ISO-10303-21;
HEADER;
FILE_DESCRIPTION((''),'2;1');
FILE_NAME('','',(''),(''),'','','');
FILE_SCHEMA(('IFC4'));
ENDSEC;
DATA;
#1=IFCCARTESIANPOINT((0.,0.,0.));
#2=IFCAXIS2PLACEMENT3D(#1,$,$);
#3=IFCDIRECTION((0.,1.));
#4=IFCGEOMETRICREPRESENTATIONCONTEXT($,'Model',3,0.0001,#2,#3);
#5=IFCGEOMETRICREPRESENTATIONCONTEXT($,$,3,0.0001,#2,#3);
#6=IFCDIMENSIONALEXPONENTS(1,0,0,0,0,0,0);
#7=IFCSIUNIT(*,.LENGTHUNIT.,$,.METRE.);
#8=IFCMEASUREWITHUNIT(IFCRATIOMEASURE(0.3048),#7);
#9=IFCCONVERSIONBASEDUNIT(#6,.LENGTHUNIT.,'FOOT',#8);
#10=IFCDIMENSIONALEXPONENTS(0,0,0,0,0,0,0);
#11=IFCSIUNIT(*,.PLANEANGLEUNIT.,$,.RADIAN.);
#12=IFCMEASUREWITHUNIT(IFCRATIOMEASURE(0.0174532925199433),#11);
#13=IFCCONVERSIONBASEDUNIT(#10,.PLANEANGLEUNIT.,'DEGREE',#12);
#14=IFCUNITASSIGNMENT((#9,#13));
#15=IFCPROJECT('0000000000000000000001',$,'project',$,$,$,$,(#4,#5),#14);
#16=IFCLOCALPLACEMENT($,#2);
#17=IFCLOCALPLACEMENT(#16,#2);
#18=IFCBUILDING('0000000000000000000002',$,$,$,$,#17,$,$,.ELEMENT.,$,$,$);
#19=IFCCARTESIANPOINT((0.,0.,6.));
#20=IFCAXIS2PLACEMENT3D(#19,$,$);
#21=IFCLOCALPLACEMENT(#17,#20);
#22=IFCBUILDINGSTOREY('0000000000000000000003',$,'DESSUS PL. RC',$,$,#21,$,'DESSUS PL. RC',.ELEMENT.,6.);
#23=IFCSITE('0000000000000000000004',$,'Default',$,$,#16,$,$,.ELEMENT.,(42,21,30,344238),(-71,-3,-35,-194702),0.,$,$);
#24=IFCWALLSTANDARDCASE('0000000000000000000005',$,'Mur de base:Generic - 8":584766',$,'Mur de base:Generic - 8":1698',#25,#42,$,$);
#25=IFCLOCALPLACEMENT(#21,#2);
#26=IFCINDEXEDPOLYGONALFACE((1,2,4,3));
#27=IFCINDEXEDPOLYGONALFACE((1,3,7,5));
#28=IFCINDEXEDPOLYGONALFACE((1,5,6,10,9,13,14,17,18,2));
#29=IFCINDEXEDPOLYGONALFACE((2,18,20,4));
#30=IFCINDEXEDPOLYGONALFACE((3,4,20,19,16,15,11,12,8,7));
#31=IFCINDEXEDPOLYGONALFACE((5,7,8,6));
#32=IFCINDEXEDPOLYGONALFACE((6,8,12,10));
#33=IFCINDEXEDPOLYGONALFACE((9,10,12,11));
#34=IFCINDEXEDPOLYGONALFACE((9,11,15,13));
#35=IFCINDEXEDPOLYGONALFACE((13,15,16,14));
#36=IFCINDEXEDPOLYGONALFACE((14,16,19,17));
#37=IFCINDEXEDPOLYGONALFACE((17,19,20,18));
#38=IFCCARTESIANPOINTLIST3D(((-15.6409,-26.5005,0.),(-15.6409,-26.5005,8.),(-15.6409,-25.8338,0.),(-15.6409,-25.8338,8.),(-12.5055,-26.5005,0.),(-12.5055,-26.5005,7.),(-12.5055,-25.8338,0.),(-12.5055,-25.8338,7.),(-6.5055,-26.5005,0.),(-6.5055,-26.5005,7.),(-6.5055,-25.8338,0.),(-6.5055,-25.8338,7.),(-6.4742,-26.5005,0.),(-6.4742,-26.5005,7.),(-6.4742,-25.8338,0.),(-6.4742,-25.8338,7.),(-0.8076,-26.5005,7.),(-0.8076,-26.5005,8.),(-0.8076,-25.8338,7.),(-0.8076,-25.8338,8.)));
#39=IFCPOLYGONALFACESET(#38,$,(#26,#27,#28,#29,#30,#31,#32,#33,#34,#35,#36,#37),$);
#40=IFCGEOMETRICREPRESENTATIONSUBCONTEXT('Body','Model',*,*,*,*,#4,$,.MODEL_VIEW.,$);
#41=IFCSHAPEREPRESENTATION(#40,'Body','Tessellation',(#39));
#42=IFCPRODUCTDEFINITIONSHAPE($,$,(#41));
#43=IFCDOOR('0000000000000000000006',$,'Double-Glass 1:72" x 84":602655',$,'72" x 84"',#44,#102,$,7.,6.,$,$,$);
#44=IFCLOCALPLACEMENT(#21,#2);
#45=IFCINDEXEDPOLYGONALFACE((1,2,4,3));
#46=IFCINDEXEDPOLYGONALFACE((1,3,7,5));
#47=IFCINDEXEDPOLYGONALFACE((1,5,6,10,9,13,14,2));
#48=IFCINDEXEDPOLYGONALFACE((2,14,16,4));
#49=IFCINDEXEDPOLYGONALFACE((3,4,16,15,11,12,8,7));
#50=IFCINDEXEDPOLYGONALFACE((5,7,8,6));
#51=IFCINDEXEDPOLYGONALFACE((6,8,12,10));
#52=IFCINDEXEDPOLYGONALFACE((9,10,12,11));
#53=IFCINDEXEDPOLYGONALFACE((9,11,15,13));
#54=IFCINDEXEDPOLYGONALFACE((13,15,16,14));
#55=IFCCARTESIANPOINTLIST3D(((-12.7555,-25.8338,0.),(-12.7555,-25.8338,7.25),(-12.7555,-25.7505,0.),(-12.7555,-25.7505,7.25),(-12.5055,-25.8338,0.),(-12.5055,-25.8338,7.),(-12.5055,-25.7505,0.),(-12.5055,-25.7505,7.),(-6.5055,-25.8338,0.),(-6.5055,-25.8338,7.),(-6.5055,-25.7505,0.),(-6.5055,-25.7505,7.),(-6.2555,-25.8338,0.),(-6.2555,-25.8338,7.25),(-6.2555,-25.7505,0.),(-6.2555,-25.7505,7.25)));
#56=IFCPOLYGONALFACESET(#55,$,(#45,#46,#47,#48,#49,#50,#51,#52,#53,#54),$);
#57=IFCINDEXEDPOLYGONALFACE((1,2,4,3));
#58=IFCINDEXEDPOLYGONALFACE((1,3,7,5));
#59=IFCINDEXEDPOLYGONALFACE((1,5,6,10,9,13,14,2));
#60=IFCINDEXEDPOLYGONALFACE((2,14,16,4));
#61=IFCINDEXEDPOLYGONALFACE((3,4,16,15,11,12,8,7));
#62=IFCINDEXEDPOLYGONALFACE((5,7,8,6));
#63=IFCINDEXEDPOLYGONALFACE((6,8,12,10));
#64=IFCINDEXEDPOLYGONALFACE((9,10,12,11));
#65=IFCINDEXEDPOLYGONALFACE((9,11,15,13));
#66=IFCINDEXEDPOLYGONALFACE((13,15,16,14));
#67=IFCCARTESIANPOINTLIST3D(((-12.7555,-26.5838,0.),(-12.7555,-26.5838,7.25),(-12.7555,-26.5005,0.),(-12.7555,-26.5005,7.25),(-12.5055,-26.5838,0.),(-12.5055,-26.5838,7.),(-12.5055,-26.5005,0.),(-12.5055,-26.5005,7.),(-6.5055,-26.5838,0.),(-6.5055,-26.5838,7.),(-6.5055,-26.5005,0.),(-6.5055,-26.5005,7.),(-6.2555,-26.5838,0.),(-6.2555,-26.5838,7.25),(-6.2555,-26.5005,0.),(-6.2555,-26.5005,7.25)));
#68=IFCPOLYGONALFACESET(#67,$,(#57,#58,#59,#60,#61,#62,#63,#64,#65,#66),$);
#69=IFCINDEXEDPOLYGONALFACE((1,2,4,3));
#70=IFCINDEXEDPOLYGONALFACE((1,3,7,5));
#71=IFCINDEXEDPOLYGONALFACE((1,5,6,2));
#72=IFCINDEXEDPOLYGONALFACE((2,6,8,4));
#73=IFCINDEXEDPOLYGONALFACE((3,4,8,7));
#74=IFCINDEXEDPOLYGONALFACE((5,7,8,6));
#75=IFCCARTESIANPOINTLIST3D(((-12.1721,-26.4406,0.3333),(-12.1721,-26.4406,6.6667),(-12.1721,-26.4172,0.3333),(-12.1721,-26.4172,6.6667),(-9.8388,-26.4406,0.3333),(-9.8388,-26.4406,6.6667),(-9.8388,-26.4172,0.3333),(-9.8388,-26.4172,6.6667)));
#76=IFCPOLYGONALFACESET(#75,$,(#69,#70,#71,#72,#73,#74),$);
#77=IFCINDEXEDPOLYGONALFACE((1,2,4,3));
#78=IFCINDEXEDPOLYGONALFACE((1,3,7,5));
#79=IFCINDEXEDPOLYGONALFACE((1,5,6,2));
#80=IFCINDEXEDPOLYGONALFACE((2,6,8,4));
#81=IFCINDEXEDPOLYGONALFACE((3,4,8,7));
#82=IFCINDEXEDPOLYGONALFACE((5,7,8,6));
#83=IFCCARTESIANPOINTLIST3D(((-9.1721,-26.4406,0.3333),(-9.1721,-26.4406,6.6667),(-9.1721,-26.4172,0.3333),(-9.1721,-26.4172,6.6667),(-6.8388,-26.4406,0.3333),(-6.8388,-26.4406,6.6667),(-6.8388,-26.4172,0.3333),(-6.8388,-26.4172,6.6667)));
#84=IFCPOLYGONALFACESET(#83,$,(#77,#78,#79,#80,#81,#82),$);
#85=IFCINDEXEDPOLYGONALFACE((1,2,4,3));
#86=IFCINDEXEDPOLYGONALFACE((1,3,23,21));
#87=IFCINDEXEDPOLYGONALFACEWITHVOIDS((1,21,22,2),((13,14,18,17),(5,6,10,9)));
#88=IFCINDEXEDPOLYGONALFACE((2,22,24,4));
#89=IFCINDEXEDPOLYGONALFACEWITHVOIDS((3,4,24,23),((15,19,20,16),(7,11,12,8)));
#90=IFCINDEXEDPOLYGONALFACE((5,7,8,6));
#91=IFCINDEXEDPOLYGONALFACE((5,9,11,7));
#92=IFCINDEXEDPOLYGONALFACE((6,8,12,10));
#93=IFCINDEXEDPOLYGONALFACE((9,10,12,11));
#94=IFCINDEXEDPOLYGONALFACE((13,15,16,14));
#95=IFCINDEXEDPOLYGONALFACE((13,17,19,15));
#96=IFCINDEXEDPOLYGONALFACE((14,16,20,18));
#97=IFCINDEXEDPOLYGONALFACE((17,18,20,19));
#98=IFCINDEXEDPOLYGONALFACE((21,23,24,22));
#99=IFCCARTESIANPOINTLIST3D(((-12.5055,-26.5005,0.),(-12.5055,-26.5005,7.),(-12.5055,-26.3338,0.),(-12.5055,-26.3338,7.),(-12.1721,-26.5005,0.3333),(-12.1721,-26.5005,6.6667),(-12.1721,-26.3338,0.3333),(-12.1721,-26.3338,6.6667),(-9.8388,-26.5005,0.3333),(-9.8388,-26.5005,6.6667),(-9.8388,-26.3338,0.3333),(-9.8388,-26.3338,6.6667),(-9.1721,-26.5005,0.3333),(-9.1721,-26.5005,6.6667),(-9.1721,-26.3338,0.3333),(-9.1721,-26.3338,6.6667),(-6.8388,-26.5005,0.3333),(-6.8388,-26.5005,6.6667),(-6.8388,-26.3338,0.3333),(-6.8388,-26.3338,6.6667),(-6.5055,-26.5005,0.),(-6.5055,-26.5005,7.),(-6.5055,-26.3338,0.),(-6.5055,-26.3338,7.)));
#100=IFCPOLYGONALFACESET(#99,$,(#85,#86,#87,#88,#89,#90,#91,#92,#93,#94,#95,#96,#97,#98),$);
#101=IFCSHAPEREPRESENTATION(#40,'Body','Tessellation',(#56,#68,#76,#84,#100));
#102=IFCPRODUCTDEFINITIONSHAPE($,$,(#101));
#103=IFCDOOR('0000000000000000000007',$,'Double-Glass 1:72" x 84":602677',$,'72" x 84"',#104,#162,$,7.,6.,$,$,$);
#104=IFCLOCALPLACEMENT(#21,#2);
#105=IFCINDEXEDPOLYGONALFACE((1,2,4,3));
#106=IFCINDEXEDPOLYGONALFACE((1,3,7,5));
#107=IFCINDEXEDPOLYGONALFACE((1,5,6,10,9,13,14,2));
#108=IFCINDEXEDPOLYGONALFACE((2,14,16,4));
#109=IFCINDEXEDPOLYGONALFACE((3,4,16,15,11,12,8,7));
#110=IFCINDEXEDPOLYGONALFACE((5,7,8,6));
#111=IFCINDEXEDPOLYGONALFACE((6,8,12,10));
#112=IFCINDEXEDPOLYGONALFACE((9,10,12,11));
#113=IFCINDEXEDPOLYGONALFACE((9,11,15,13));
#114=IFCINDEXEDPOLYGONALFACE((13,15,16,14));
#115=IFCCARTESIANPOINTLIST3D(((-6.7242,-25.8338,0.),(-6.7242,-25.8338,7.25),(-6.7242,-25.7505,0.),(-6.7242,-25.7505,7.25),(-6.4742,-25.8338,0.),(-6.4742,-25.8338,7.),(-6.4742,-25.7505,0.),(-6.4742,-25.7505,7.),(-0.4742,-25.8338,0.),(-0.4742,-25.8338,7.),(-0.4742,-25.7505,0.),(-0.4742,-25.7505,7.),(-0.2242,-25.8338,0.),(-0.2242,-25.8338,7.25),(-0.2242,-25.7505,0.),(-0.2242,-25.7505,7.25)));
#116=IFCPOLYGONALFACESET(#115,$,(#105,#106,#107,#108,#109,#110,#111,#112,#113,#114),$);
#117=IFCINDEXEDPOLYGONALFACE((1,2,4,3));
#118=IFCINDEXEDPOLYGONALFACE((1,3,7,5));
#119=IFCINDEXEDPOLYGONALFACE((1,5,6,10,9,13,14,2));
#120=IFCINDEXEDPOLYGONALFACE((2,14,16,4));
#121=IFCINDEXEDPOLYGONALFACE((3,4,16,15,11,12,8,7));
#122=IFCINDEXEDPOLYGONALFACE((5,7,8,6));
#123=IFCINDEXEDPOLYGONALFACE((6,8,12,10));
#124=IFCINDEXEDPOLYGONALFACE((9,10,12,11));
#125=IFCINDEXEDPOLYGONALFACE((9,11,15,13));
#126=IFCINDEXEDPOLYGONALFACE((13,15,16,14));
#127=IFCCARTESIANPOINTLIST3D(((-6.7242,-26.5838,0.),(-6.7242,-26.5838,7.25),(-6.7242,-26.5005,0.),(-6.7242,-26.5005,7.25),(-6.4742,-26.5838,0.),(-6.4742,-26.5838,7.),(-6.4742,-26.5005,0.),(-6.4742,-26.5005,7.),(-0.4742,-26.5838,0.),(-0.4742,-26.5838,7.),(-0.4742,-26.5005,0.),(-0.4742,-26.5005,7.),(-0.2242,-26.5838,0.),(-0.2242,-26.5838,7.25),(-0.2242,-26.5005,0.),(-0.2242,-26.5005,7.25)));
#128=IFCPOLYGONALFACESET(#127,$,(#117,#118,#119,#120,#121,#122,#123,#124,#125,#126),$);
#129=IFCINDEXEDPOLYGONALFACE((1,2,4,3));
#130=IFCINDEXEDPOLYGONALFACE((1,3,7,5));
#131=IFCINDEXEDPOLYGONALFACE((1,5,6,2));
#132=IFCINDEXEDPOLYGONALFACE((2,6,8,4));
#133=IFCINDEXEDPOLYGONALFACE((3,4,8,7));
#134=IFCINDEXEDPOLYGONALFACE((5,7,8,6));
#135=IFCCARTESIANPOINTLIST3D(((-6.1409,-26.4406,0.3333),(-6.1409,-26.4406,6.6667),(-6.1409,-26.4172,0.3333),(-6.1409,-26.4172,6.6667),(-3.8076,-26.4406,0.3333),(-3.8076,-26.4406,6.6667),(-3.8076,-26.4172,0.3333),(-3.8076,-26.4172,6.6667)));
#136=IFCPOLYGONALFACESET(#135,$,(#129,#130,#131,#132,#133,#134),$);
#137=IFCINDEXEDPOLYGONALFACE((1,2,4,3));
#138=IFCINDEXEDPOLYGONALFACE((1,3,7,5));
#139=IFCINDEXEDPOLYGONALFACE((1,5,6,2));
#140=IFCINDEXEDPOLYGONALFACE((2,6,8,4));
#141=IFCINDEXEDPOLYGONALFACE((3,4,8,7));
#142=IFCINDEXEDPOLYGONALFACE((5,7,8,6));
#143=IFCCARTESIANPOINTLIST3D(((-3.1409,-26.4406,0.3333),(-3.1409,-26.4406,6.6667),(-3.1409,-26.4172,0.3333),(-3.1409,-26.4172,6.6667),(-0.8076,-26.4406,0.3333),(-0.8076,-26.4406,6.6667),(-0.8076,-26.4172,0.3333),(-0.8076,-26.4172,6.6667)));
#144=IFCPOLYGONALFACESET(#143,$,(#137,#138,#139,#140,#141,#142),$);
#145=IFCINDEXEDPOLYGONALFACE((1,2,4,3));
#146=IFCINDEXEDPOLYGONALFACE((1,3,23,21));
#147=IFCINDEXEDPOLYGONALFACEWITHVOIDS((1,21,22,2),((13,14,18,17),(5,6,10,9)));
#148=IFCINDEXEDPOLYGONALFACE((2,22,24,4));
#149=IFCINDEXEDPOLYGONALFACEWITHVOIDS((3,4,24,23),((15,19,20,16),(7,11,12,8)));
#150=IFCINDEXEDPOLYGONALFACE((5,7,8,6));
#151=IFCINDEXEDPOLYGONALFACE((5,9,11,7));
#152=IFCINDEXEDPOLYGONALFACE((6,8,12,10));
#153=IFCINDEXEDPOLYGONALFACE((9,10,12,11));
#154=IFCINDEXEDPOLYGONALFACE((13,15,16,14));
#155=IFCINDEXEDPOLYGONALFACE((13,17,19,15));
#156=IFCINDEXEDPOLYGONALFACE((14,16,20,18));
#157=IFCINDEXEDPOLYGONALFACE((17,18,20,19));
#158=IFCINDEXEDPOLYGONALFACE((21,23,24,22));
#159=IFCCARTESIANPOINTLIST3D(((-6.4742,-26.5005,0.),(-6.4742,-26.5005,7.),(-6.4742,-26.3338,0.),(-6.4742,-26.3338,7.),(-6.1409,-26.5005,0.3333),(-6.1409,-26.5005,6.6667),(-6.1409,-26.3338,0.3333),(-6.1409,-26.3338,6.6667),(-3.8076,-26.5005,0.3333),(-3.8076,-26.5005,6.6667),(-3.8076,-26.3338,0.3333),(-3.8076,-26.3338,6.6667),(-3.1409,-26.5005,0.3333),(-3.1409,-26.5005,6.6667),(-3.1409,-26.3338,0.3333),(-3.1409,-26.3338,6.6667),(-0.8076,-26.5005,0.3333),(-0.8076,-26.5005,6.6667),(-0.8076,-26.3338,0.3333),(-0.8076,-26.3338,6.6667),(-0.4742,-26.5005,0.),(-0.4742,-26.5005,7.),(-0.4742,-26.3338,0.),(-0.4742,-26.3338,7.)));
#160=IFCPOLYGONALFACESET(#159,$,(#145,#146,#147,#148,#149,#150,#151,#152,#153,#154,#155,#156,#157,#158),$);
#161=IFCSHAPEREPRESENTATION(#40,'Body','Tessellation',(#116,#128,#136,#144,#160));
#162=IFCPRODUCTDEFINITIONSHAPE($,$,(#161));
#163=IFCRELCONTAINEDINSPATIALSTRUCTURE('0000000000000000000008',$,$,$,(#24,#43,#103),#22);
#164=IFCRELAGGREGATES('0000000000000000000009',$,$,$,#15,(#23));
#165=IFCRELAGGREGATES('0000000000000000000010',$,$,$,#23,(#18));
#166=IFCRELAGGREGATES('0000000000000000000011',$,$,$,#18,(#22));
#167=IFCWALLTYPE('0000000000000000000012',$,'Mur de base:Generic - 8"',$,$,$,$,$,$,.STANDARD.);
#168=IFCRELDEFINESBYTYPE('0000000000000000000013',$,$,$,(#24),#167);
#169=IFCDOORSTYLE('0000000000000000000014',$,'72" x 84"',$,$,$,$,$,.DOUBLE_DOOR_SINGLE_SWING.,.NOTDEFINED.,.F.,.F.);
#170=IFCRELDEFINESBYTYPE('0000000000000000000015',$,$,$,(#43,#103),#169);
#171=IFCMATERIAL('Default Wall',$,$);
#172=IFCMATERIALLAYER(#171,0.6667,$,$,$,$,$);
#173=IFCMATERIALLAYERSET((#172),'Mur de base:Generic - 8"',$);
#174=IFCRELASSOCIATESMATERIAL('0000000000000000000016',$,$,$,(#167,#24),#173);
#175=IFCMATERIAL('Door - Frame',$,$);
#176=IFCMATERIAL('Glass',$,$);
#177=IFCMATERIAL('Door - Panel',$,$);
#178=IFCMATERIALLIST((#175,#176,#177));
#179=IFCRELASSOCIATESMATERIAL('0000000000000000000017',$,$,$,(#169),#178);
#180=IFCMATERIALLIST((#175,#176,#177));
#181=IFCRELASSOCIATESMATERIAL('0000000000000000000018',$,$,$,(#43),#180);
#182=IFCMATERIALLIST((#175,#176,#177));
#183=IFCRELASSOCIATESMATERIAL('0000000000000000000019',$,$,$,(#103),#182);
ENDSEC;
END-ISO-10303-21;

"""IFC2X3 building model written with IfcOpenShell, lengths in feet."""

from ifc_helpers import new_model, entity, si_unit, converted_unit, direction, frame, frame_2d, origin, origin_2d_with_axis, place, context, subcontext, project, spatial, polyline, rectangle, outline, extrude, source, transform, mapped, material, material_list, layer, layer_set, layer_usage, type_object, type_shapes, element, fill, save


model = new_model("IFC2X3")

# Units and contexts
model_context = context("Model", 3, precision=0.0001, world=origin(), true_north=direction((0.0, 1.0)))
context_of_model = context(None, 3, precision=0.0001, world=origin(), true_north=direction((0.0, 1.0)))
body_context = subcontext(model_context, "Body", "Model", "MODEL_VIEW")
ifc_project = project(units=[converted_unit("LENGTHUNIT", "FOOT", entity("IfcRatioMeasure", 0.3048), si_unit("LENGTHUNIT", "METRE"), dimensions=[1, 0, 0, 0, 0, 0, 0]), converted_unit("PLANEANGLEUNIT", "DEGREE", entity("IfcRatioMeasure", 0.0174532925199433), si_unit("PLANEANGLEUNIT", "RADIAN"), dimensions=[0, 0, 0, 0, 0, 0, 0])], contexts=[model_context, context_of_model])

# Site, building, storey
site_placement = place(None, origin())
site = spatial("IfcSite", under=ifc_project, at=site_placement, Name="Default", CompositionType="ELEMENT", RefLatitude=(42, 21, 30, 344238), RefLongitude=(-71, -3, -35, -194702), RefElevation=0.0)
building_placement = place(site_placement, origin())
building = spatial("IfcBuilding", under=site, at=building_placement, CompositionType="ELEMENT")
storey_placement = place(building_placement, frame((0.0, 0.0, 6.0)))
storey = spatial("IfcBuildingStorey", under=building, at=storey_placement, Name="DESSUS PL. RC", LongName="DESSUS PL. RC", CompositionType="ELEMENT", Elevation=6.0)

# Shared definitions
ifc_material_1 = material(Name="Default Wall")
ifc_material_2 = material(Name="Door - Frame")
ifc_material_3 = material(Name="Glass")
ifc_material_4 = material(Name="Door - Panel")

# Shared definitions
ifc_layer_1 = layer(ifc_material_1, 0.6667)
ifc_layer_set_1 = layer_set([ifc_layer_1], Name="Mur de base:Generic - 8\"")
wall_type_1 = type_object("IfcWallType", Name="Mur de base:Generic - 8\"", PredefinedType="STANDARD", material=ifc_layer_set_1)
ifc_material_list_1 = material_list([ifc_material_2, ifc_material_3, ifc_material_4])
door_style_1 = type_object("IfcDoorStyle", Name="72\" x 84\"", ConstructionType="NOTDEFINED", OperationType="DOUBLE_DOOR_SINGLE_SWING", ParameterTakesPrecedence=False, Sizeable=False, material=ifc_material_list_1)
shared_shape_1 = source(origin(), body_context, "Body", "SweptSolid", [
    extrude(outline(polyline([(-3.25, -3.5625), (-3.0, -3.5625), (-3.0, 3.4375), (3.0, 3.4375), (3.0, -3.5625), (3.25, -3.5625), (3.25, 3.6875), (-3.25, 3.6875), (-3.25, -3.5625)])), frame((3.0, -0.0833, 3.5625), z_axis=(0.0, 1.0, 0.0), x_axis=(-1.0, 0.0, 0.0)), (0.0, 0.0, 1.0), 0.0833),
    extrude(outline(polyline([(-3.0, -3.4375), (-3.0, 3.5625), (-3.25, 3.5625), (-3.25, -3.6875), (3.25, -3.6875), (3.25, 3.5625), (3.0, 3.5625), (3.0, -3.4375), (-3.0, -3.4375)])), frame((3.0, 0.6667, 3.5625), z_axis=(0.0, -1.0, 0.0), x_axis=(-1.0, 0.0, 0.0)), (0.0, 0.0, -1.0), 0.0833),
    extrude(rectangle(XDim=0.0234, YDim=2.3333, at=frame_2d((0.0, 0.0), x_axis=(1.0, 0.0))), frame((4.5, 0.5951, 0.3333), z_axis=(0.0, 0.0, 1.0), x_axis=(0.0, 1.0, 0.0)), (0.0, 0.0, 1.0), 6.3333),
    extrude(rectangle(XDim=0.0234, YDim=2.3333, at=origin_2d_with_axis()), frame((1.5, 0.5951, 0.3333), z_axis=(0.0, 0.0, 1.0), x_axis=(0.0, 1.0, 0.0)), (0.0, 0.0, 1.0), 6.3333),
    extrude(outline(polyline([(-3.5, -3.0), (3.5, -3.0), (3.5, 3.0), (-3.5, 3.0), (-3.5, -3.0)]), holes=[polyline([(-3.1667, 0.3333), (-3.1667, 2.6667), (3.1667, 2.6667), (3.1667, 0.3333), (-3.1667, 0.3333)]), polyline([(-3.1667, -2.6667), (-3.1667, -0.3333), (3.1667, -0.3333), (3.1667, -2.6667), (-3.1667, -2.6667)])]), frame((3.0, 0.5, 3.5), z_axis=(0.0, 1.0, 0.0), x_axis=(0.0, 0.0, -1.0)), (0.0, 0.0, 1.0), 0.1667),
])
type_shapes(door_style_1, [shared_shape_1])

# Wall, openings, doors
ifc_layer_usage_1 = layer_usage(ifc_layer_set_1, "AXIS2", "NEGATIVE", 0.3333)
wall_1_placement = place(storey_placement, frame((-0.8076, -26.1672, 0.0), z_axis=(0.0, 0.0, 1.0), x_axis=(-1.0, 0.0, 0.0)))
wall_1 = element("IfcWallStandardCase", 1, at=wall_1_placement, inside=storey, type_object=wall_type_1, material=ifc_layer_usage_1, Name="Mur de base:Generic - 8\":584766", ObjectType="Mur de base:Generic - 8\":1698", context=body_context, shape_type="SweptSolid", body=[
    extrude(rectangle(XDim=14.8333, YDim=0.6667, at=frame_2d((7.4167, 0.0), x_axis=(-1.0, 0.0))), origin(), (0.0, 0.0, 1.0), 8.0),
])
opening_1_placement = place(wall_1_placement, frame((5.6979, -0.3333, 0.0)))
opening_1 = element("IfcOpeningElement", 2, at=opening_1_placement, cuts=wall_1, ObjectType="Opening", context=body_context, shape_type="SweptSolid", body=[
    extrude(rectangle(XDim=6.0, YDim=7.0, at=frame_2d((3.5, 3.0), x_axis=(0.0, 1.0))), frame((0.0, 0.0, 0.0), z_axis=(0.0, 1.0, 0.0), x_axis=(0.0, 0.0, 1.0)), (0.0, 0.0, 1.0), 0.6667),
])
opening_2_placement = place(wall_1_placement, frame((-0.3333, -0.3333, 0.0)))
opening_2 = element("IfcOpeningElement", 3, at=opening_2_placement, cuts=wall_1, ObjectType="Opening", context=body_context, shape_type="SweptSolid", body=[
    extrude(rectangle(XDim=6.0, YDim=7.0, at=frame_2d((3.5, 3.0), x_axis=(0.0, 1.0))), frame((0.0, 0.0, 0.0), z_axis=(0.0, 1.0, 0.0), x_axis=(0.0, 0.0, 1.0)), (0.0, 0.0, 1.0), 0.6667),
])
ifc_material_list_2 = material_list([ifc_material_2, ifc_material_3, ifc_material_4])
door_1_placement = place(opening_1_placement, origin())
door_1 = element("IfcDoor", 4, at=door_1_placement, inside=storey, type_object=door_style_1, material=ifc_material_list_2, Name="Double-Glass 1:72\" x 84\":602655", ObjectType="72\" x 84\"", OverallHeight=7.0, OverallWidth=6.0, context=body_context, shape_type="MappedRepresentation", body=[
    mapped(shared_shape_1, transform((0.0, 0.0, 0.0), scale=1.0)),
])
fill(opening_1, door_1)
ifc_material_list_3 = material_list([ifc_material_2, ifc_material_3, ifc_material_4])
door_2_placement = place(opening_2_placement, origin())
door_2 = element("IfcDoor", 5, at=door_2_placement, inside=storey, type_object=door_style_1, material=ifc_material_list_3, Name="Double-Glass 1:72\" x 84\":602677", ObjectType="72\" x 84\"", OverallHeight=7.0, OverallWidth=6.0, context=body_context, shape_type="MappedRepresentation", body=[
    mapped(shared_shape_1, transform((0.0, 0.0, 0.0), scale=1.0)),
])
fill(opening_2, door_2)

save(model, "model.ifc")
